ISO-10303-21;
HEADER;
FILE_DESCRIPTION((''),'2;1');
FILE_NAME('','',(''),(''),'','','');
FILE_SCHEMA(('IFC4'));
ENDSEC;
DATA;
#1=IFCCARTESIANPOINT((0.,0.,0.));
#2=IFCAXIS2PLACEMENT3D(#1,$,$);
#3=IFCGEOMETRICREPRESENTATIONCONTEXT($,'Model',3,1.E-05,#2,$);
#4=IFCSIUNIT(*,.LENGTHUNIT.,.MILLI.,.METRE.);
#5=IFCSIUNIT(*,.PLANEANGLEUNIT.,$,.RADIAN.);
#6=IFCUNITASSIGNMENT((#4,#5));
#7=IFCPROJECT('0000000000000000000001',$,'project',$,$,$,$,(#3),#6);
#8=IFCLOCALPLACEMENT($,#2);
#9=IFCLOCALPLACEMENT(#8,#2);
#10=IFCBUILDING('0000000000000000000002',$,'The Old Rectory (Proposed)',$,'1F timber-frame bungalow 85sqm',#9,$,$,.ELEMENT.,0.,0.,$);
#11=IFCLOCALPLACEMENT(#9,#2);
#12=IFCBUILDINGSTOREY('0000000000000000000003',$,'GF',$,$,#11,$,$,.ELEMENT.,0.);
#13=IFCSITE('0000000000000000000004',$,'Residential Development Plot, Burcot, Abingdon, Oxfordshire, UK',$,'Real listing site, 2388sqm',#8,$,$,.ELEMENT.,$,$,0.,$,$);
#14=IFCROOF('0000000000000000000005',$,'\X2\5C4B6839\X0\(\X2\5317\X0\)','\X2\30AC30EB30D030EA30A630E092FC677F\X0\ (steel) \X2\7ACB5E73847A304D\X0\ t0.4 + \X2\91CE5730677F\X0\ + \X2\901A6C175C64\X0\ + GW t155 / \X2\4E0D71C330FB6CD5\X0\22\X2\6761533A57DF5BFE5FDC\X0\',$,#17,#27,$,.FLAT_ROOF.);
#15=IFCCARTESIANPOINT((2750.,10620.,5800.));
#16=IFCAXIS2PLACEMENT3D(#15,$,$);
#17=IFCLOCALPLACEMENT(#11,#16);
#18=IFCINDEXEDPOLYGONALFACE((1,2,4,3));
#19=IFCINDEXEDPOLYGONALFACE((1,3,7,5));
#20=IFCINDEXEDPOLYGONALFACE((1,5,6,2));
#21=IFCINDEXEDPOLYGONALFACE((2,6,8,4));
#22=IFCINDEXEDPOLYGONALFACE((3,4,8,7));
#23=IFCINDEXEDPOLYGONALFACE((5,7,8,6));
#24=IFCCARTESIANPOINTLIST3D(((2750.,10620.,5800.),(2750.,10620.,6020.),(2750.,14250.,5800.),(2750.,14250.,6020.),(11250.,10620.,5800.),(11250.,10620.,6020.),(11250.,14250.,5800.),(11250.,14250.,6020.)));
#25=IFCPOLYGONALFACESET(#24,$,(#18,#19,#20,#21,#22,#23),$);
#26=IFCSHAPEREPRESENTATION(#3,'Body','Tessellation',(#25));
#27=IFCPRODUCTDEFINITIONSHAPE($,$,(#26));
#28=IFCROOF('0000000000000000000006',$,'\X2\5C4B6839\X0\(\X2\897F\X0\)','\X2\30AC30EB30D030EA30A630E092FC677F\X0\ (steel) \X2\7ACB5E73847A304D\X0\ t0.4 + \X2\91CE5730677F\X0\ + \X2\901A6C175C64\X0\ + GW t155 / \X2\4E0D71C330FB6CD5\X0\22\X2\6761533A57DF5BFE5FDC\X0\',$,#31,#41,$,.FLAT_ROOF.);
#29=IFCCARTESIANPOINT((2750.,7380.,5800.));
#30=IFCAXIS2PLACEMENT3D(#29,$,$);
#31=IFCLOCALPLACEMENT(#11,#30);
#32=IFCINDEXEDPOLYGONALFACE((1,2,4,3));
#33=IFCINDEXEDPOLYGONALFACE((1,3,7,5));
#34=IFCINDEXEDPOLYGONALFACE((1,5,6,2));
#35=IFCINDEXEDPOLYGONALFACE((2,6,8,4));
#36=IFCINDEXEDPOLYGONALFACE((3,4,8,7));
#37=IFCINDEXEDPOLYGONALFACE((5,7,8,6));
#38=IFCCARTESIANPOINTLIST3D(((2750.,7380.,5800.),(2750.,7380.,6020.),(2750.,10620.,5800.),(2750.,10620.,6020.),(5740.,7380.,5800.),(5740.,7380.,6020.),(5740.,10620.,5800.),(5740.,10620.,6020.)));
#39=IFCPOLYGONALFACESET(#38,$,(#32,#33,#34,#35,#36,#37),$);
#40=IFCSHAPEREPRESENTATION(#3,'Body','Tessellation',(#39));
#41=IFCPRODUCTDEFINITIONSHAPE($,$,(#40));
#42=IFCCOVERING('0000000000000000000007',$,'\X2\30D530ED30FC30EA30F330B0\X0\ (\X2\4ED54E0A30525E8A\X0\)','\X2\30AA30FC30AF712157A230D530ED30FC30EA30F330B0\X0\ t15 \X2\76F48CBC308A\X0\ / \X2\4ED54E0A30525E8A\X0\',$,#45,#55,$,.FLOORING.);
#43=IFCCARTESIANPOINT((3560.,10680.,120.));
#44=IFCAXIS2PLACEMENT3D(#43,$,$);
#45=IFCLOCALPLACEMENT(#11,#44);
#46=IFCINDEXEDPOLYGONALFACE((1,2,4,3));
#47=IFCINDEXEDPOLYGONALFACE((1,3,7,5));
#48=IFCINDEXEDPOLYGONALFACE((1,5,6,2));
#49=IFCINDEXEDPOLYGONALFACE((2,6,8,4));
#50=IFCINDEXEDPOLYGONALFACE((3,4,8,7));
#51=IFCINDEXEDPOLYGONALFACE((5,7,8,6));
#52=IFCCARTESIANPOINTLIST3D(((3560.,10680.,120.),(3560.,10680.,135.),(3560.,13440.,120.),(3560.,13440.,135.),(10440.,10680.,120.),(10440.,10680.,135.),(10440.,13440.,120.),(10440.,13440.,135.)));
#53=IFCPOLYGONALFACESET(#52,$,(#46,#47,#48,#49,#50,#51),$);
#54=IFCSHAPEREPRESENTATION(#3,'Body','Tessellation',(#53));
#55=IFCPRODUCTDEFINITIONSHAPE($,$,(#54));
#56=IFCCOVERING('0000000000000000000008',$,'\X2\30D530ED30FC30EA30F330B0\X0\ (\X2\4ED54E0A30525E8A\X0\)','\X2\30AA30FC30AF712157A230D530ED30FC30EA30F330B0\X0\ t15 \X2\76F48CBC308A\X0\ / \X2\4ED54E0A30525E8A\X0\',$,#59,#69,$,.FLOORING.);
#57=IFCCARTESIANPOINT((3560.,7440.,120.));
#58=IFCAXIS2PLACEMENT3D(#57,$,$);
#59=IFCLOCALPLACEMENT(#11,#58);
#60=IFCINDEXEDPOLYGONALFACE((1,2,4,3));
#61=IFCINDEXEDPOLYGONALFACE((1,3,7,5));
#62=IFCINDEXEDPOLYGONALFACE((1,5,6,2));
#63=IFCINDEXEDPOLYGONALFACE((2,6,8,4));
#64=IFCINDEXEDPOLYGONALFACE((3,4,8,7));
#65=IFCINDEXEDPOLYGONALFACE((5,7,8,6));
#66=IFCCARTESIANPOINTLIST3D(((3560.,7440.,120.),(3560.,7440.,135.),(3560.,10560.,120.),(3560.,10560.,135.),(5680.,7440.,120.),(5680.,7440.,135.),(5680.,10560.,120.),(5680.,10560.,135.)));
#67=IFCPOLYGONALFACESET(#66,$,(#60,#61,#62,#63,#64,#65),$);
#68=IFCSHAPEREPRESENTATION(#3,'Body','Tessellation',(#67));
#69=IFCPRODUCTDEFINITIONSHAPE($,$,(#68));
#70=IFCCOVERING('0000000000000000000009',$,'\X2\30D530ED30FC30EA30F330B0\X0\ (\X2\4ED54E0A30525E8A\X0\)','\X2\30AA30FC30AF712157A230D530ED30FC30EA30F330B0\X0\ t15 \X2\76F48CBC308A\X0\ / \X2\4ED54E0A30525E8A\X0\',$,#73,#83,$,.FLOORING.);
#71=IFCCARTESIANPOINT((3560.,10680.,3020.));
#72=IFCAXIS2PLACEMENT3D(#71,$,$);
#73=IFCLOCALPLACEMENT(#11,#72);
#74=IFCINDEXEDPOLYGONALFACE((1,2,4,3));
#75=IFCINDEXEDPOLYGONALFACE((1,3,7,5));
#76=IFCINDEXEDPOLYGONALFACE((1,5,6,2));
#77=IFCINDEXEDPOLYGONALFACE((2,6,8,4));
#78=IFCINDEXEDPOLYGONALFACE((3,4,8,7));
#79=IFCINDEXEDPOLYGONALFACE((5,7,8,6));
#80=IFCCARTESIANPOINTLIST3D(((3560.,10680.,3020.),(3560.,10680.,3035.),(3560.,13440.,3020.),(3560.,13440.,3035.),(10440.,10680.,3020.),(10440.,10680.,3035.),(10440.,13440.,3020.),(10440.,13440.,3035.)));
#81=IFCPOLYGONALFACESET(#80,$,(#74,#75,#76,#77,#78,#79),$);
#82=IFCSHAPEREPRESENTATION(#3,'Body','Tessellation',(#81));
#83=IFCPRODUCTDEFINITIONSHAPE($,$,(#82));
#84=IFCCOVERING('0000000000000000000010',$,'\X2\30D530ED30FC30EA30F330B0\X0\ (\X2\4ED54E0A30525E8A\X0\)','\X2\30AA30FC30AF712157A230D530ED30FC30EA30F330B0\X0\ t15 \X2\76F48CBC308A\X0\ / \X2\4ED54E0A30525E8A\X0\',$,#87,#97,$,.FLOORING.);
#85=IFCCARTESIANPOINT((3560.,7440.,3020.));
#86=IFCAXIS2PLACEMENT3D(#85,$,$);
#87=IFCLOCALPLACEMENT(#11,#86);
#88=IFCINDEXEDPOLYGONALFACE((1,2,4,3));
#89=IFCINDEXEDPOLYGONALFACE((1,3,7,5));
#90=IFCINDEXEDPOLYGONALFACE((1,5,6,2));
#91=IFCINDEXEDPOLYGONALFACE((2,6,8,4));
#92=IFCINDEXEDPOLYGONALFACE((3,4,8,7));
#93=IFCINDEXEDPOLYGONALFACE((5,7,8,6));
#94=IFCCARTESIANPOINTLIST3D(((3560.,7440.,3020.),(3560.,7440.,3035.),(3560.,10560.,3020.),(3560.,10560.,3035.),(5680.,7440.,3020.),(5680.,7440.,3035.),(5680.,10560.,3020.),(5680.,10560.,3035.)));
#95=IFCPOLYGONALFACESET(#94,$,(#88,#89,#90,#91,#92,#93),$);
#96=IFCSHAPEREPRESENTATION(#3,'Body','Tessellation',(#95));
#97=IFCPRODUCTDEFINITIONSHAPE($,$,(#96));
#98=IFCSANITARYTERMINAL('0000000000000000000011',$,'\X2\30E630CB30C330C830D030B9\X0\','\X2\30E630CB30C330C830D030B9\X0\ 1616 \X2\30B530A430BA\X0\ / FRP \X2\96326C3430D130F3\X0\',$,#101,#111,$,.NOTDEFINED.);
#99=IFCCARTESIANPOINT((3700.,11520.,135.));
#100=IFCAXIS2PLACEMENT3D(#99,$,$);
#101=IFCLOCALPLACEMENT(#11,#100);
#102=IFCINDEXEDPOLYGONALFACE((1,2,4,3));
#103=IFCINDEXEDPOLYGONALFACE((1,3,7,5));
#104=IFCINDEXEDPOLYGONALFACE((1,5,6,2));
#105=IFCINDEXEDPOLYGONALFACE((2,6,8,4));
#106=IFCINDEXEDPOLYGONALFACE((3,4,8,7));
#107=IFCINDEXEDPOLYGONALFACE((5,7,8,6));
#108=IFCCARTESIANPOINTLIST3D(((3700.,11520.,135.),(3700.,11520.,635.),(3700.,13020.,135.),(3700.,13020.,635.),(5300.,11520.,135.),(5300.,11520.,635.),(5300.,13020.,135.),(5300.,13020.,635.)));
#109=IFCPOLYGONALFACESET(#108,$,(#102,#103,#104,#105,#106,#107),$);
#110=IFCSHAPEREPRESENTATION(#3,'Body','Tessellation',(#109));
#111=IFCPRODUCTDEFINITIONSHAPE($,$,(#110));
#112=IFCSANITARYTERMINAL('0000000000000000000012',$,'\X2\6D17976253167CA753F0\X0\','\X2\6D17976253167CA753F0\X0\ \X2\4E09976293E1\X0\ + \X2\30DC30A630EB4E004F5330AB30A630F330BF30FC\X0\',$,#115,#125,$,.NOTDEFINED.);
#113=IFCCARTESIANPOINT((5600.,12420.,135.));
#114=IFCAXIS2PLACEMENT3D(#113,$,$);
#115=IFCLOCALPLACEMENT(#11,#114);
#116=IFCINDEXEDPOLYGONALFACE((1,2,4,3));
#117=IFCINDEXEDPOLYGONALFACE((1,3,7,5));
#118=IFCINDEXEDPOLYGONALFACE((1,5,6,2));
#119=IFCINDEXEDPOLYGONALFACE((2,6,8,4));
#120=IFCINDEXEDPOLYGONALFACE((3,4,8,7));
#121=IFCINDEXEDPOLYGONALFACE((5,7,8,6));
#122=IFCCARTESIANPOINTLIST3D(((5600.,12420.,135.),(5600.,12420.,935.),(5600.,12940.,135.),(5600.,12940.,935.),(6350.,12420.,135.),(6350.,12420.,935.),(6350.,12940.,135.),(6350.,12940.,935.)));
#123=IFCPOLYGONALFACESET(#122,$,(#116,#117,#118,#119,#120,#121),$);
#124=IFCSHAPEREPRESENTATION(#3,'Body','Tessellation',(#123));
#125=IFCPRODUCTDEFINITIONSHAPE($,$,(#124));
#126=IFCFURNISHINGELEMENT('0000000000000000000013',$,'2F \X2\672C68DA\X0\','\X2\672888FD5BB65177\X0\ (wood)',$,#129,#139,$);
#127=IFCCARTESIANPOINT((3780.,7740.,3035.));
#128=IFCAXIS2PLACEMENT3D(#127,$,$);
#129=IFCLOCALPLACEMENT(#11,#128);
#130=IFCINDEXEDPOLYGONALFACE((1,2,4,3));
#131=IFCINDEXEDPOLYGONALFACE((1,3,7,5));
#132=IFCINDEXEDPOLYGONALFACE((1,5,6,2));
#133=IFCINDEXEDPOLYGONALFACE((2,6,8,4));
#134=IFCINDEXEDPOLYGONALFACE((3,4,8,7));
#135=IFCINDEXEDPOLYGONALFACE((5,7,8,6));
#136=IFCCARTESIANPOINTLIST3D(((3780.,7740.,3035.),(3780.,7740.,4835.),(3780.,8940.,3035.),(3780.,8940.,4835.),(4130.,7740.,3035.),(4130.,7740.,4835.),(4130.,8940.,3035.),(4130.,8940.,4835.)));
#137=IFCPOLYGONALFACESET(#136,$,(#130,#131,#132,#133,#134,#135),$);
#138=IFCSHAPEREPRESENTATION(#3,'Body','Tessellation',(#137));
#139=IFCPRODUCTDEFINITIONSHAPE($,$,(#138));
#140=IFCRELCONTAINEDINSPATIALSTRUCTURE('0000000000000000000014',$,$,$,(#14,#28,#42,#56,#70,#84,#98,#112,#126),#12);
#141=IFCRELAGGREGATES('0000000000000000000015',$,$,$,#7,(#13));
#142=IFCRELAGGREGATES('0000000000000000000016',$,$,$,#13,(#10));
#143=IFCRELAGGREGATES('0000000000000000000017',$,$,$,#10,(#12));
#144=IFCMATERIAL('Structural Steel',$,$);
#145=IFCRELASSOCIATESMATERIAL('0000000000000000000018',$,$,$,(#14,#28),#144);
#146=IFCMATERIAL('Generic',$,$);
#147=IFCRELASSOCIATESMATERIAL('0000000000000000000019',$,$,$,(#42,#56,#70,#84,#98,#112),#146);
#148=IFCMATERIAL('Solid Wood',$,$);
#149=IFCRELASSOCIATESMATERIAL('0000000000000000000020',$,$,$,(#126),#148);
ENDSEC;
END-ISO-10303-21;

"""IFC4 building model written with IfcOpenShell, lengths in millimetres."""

from ifc_helpers import new_model, si_unit, frame, frame_2d, origin, place, context, project, spatial, rectangle, extrude, material, element, save


model = new_model("IFC4")

# Units and contexts
model_context = context("Model", 3, precision=1e-05, world=origin())
ifc_project = project(units=[si_unit("LENGTHUNIT", "METRE", prefix="MILLI"), si_unit("PLANEANGLEUNIT", "RADIAN")], contexts=[model_context])

# Site, building, storey
site_placement = place(None, origin())
site = spatial("IfcSite", under=ifc_project, at=site_placement, Name="Residential Development Plot, Burcot, Abingdon, Oxfordshire, UK", ObjectType="Real listing site, 2388sqm", CompositionType="ELEMENT", RefElevation=0.0)
building_placement = place(site_placement, origin())
building = spatial("IfcBuilding", under=site, at=building_placement, Name="The Old Rectory (Proposed)", ObjectType="1F timber-frame bungalow 85sqm", CompositionType="ELEMENT", ElevationOfRefHeight=0.0, ElevationOfTerrain=0.0)
storey_placement = place(building_placement, origin())
storey = spatial("IfcBuildingStorey", under=building, at=storey_placement, Name="GF", CompositionType="ELEMENT", Elevation=0.0)

# Shared definitions
ifc_material_1 = material(Name="Solid Wood")

# Roofs
ifc_material_2 = material(Name="Structural Steel")
for number, where, name in (
    (1, (2750.0, 10620.0, 5800.0), "屋根(北)"),
):
    element("IfcRoof", number, at=place(storey_placement, frame(where)), inside=storey, material=ifc_material_2, Name=name, Description="ガルバリウム鋼板 (steel) 立平葺き t0.4 + 野地板 + 通気層 + GW t155 / 不燃・法22条区域対応", PredefinedType="FLAT_ROOF", context=model_context, shape_type="SweptSolid", body=[
        extrude(rectangle(XDim=8500.0, YDim=3630.0, at=frame_2d((4250.0, 1815.0))), frame((2750.0, 10620.0, 5800.0)), (0.0, 0.0, 1.0), 220.0),
    ])
roof_placement = place(storey_placement, frame((2750.0, 7380.0, 5800.0)))
element("IfcRoof", 2, at=roof_placement, inside=storey, material=ifc_material_2, Name="屋根(西)", Description="ガルバリウム鋼板 (steel) 立平葺き t0.4 + 野地板 + 通気層 + GW t155 / 不燃・法22条区域対応", PredefinedType="FLAT_ROOF", context=model_context, shape_type="SweptSolid", body=[
    extrude(rectangle(XDim=2990.0, YDim=3240.0, at=frame_2d((1495.0, 1620.0))), frame((2750.0, 7380.0, 5800.0)), (0.0, 0.0, 1.0), 220.0),
])

# Coverings
ifc_material_3 = material(Name="Generic")
covering_1_placement = place(storey_placement, frame((3560.0, 10680.0, 120.0)))
element("IfcCovering", 3, at=covering_1_placement, inside=storey, material=ifc_material_3, Name="フローリング (仕上げ床)", Description="オーク無垢フローリング t15 直貼り / 仕上げ床", PredefinedType="FLOORING", context=model_context, shape_type="SweptSolid", body=[
    extrude(rectangle(XDim=6880.0, YDim=2760.0, at=frame_2d((3440.0, 1380.0))), frame((3560.0, 10680.0, 120.0)), (0.0, 0.0, 1.0), 15.0),
])
covering_2_placement = place(storey_placement, frame((3560.0, 7440.0, 120.0)))
element("IfcCovering", 4, at=covering_2_placement, inside=storey, material=ifc_material_3, Name="フローリング (仕上げ床)", Description="オーク無垢フローリング t15 直貼り / 仕上げ床", PredefinedType="FLOORING", context=model_context, shape_type="SweptSolid", body=[
    extrude(rectangle(XDim=2120.0, YDim=3120.0, at=frame_2d((1060.0, 1560.0))), frame((3560.0, 7440.0, 120.0)), (0.0, 0.0, 1.0), 15.0),
])
covering_3_placement = place(storey_placement, frame((3560.0, 10680.0, 3020.0)))
element("IfcCovering", 5, at=covering_3_placement, inside=storey, material=ifc_material_3, Name="フローリング (仕上げ床)", Description="オーク無垢フローリング t15 直貼り / 仕上げ床", PredefinedType="FLOORING", context=model_context, shape_type="SweptSolid", body=[
    extrude(rectangle(XDim=6880.0, YDim=2760.0, at=frame_2d((3440.0, 1380.0))), frame((3560.0, 10680.0, 3020.0)), (0.0, 0.0, 1.0), 15.0),
])
covering_4_placement = place(storey_placement, frame((3560.0, 7440.0, 3020.0)))
element("IfcCovering", 6, at=covering_4_placement, inside=storey, material=ifc_material_3, Name="フローリング (仕上げ床)", Description="オーク無垢フローリング t15 直貼り / 仕上げ床", PredefinedType="FLOORING", context=model_context, shape_type="SweptSolid", body=[
    extrude(rectangle(XDim=2120.0, YDim=3120.0, at=frame_2d((1060.0, 1560.0))), frame((3560.0, 7440.0, 3020.0)), (0.0, 0.0, 1.0), 15.0),
])

# Sanitary terminals
sanitary_terminal_1_placement = place(storey_placement, frame((3700.0, 11520.0, 135.0)))
element("IfcSanitaryTerminal", 7, at=sanitary_terminal_1_placement, inside=storey, material=ifc_material_3, Name="ユニットバス", Description="ユニットバス 1616 サイズ / FRP 防水パン", PredefinedType="NOTDEFINED", context=model_context, shape_type="SweptSolid", body=[
    extrude(rectangle(XDim=1600.0, YDim=1500.0, at=frame_2d((800.0, 750.0))), frame((3700.0, 11520.0, 135.0)), (0.0, 0.0, 1.0), 500.0),
])
sanitary_terminal_2_placement = place(storey_placement, frame((5600.0, 12420.0, 135.0)))
element("IfcSanitaryTerminal", 8, at=sanitary_terminal_2_placement, inside=storey, material=ifc_material_3, Name="洗面化粧台", Description="洗面化粧台 三面鏡 + ボウル一体カウンター", PredefinedType="NOTDEFINED", context=model_context, shape_type="SweptSolid", body=[
    extrude(rectangle(XDim=750.0, YDim=520.0, at=frame_2d((375.0, 260.0))), frame((5600.0, 12420.0, 135.0)), (0.0, 0.0, 1.0), 800.0),
])

# Furnishing element
furnishing_placement = place(storey_placement, frame((3780.0, 7740.0, 3035.0)))
element("IfcFurnishingElement", 9, at=furnishing_placement, inside=storey, material=ifc_material_1, Name="2F 本棚", Description="木製家具 (wood)", context=model_context, shape_type="SweptSolid", body=[
    extrude(rectangle(XDim=350.0, YDim=1200.0, at=frame_2d((175.0, 600.0))), frame((3780.0, 7740.0, 3035.0)), (0.0, 0.0, 1.0), 1800.0),
])

save(model, "model.ifc")
